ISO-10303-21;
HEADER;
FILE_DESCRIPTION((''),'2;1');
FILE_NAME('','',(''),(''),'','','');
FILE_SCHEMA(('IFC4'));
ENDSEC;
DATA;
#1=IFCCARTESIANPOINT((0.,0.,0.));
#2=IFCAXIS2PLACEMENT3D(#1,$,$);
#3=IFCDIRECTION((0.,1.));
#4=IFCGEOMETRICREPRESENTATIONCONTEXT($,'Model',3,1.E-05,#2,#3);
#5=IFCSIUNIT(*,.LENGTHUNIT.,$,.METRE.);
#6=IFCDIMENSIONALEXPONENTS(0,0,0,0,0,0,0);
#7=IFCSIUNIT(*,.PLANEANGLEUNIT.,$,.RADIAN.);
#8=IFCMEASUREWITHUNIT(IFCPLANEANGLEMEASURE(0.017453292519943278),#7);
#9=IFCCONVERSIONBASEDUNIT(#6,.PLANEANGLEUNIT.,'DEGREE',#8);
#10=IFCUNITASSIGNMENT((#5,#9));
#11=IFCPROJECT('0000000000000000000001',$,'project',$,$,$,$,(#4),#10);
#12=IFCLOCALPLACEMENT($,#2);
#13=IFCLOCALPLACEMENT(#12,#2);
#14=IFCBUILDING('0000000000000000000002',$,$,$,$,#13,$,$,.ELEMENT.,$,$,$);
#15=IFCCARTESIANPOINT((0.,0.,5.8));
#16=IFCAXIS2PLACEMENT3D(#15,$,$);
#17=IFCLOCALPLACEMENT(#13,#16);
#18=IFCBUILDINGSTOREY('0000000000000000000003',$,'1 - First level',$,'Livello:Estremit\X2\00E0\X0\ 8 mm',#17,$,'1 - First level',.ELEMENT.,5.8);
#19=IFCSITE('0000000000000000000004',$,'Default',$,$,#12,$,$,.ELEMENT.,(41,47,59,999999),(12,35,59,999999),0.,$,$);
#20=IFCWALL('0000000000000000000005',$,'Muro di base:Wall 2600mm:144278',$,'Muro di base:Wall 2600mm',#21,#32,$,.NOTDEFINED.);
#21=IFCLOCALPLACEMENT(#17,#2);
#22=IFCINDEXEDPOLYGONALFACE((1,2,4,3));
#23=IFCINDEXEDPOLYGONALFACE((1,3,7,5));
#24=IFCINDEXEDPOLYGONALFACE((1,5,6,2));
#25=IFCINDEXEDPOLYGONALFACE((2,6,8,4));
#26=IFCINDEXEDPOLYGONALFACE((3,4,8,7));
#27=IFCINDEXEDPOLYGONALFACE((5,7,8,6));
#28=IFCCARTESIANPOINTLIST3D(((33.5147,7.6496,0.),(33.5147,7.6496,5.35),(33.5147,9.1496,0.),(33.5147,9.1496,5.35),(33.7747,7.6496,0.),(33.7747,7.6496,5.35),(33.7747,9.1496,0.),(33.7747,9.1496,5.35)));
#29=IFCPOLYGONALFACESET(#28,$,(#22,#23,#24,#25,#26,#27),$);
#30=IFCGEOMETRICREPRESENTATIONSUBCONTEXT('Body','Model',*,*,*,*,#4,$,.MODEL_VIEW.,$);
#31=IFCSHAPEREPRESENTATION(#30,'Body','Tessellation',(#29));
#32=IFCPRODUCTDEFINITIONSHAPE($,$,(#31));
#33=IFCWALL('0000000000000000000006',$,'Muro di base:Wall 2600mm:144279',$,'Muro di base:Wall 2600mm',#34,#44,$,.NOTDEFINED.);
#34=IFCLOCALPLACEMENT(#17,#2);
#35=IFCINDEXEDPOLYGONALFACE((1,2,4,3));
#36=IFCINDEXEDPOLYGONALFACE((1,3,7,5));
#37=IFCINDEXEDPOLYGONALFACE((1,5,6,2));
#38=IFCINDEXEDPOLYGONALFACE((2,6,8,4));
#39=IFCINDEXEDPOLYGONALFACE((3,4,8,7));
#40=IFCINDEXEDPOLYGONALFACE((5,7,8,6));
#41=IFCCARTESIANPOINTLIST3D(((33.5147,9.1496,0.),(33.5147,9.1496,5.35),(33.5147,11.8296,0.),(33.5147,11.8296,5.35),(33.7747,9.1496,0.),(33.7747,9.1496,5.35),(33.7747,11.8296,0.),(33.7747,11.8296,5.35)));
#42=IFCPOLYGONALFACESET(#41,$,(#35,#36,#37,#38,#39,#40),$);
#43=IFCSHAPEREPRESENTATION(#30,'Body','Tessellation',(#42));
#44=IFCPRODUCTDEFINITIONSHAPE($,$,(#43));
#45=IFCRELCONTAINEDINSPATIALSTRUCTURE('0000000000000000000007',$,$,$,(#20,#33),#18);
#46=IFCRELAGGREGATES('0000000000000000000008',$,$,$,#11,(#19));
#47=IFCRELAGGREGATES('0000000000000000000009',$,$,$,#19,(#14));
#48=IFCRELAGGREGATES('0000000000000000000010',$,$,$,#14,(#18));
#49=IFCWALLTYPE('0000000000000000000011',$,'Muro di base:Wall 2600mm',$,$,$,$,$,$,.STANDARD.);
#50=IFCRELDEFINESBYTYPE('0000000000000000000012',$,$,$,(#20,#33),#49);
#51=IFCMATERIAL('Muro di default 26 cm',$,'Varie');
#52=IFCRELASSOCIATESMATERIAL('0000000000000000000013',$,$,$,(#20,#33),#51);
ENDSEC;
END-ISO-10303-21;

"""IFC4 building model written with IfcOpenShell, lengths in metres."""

from ifc_helpers import new_model, entity, si_unit, converted_unit, direction, frame, origin, place, context, subcontext, project, spatial, indexed_curve, outline, extrude, material, type_object, element, save


model = new_model("IFC4")

# Units and contexts
model_context = context("Model", 3, precision=1e-05, world=origin(), true_north=direction((0.0, 1.0)))
body_context = subcontext(model_context, "Body", "Model", "MODEL_VIEW")
ifc_project = project(units=[si_unit("LENGTHUNIT", "METRE"), converted_unit("PLANEANGLEUNIT", "DEGREE", entity("IfcPlaneAngleMeasure", 0.017453292519943278), si_unit("PLANEANGLEUNIT", "RADIAN"), dimensions=[0, 0, 0, 0, 0, 0, 0])], contexts=[model_context])

# Site, building, storey
site_placement = place(None, origin())
site = spatial("IfcSite", under=ifc_project, at=site_placement, Name="Default", CompositionType="ELEMENT", RefLatitude=(41, 47, 59, 999999), RefLongitude=(12, 35, 59, 999999), RefElevation=0.0)
building_placement = place(site_placement, origin())
building = spatial("IfcBuilding", under=site, at=building_placement, CompositionType="ELEMENT")
storey_placement = place(building_placement, frame((0.0, 0.0, 5.8)))
storey = spatial("IfcBuildingStorey", under=building, at=storey_placement, Name="1 - First level", ObjectType="Livello:Estremità 8 mm", LongName="1 - First level", CompositionType="ELEMENT", Elevation=5.8)

# Walls
ifc_material_1 = material(Name="Muro di default 26 cm", Category="Varie")
wall_type_1 = type_object("IfcWallType", Name="Muro di base:Wall 2600mm", PredefinedType="STANDARD")
wall_1_placement = place(storey_placement, frame((33.6447, 7.6496, 0.0), z_axis=(0.0, 0.0, 1.0), x_axis=(0.0, 1.0, 0.0)))
element("IfcWall", 1, at=wall_1_placement, inside=storey, type_object=wall_type_1, material=ifc_material_1, Name="Muro di base:Wall 2600mm:144278", ObjectType="Muro di base:Wall 2600mm", PredefinedType="NOTDEFINED", context=body_context, shape_type="SweptSolid", body=[
    extrude(outline(indexed_curve([(1.5, 0.13), (0.0, 0.13), (0.0, -0.13), (1.5, -0.13), (1.5, 0.13)], self_intersect=False)), origin(), (0.0, 0.0, 1.0), 5.35),
])
wall_2_placement = place(storey_placement, frame((33.6447, 9.1496, 0.0), z_axis=(0.0, 0.0, 1.0), x_axis=(0.0, 1.0, 0.0)))
element("IfcWall", 2, at=wall_2_placement, inside=storey, type_object=wall_type_1, material=ifc_material_1, Name="Muro di base:Wall 2600mm:144279", ObjectType="Muro di base:Wall 2600mm", PredefinedType="NOTDEFINED", context=body_context, shape_type="SweptSolid", body=[
    extrude(outline(indexed_curve([(2.68, 0.13), (0.0, 0.13), (0.0, -0.13), (2.68, -0.13), (2.68, 0.13)], self_intersect=False)), origin(), (0.0, 0.0, 1.0), 5.35),
])

save(model, "model.ifc")
